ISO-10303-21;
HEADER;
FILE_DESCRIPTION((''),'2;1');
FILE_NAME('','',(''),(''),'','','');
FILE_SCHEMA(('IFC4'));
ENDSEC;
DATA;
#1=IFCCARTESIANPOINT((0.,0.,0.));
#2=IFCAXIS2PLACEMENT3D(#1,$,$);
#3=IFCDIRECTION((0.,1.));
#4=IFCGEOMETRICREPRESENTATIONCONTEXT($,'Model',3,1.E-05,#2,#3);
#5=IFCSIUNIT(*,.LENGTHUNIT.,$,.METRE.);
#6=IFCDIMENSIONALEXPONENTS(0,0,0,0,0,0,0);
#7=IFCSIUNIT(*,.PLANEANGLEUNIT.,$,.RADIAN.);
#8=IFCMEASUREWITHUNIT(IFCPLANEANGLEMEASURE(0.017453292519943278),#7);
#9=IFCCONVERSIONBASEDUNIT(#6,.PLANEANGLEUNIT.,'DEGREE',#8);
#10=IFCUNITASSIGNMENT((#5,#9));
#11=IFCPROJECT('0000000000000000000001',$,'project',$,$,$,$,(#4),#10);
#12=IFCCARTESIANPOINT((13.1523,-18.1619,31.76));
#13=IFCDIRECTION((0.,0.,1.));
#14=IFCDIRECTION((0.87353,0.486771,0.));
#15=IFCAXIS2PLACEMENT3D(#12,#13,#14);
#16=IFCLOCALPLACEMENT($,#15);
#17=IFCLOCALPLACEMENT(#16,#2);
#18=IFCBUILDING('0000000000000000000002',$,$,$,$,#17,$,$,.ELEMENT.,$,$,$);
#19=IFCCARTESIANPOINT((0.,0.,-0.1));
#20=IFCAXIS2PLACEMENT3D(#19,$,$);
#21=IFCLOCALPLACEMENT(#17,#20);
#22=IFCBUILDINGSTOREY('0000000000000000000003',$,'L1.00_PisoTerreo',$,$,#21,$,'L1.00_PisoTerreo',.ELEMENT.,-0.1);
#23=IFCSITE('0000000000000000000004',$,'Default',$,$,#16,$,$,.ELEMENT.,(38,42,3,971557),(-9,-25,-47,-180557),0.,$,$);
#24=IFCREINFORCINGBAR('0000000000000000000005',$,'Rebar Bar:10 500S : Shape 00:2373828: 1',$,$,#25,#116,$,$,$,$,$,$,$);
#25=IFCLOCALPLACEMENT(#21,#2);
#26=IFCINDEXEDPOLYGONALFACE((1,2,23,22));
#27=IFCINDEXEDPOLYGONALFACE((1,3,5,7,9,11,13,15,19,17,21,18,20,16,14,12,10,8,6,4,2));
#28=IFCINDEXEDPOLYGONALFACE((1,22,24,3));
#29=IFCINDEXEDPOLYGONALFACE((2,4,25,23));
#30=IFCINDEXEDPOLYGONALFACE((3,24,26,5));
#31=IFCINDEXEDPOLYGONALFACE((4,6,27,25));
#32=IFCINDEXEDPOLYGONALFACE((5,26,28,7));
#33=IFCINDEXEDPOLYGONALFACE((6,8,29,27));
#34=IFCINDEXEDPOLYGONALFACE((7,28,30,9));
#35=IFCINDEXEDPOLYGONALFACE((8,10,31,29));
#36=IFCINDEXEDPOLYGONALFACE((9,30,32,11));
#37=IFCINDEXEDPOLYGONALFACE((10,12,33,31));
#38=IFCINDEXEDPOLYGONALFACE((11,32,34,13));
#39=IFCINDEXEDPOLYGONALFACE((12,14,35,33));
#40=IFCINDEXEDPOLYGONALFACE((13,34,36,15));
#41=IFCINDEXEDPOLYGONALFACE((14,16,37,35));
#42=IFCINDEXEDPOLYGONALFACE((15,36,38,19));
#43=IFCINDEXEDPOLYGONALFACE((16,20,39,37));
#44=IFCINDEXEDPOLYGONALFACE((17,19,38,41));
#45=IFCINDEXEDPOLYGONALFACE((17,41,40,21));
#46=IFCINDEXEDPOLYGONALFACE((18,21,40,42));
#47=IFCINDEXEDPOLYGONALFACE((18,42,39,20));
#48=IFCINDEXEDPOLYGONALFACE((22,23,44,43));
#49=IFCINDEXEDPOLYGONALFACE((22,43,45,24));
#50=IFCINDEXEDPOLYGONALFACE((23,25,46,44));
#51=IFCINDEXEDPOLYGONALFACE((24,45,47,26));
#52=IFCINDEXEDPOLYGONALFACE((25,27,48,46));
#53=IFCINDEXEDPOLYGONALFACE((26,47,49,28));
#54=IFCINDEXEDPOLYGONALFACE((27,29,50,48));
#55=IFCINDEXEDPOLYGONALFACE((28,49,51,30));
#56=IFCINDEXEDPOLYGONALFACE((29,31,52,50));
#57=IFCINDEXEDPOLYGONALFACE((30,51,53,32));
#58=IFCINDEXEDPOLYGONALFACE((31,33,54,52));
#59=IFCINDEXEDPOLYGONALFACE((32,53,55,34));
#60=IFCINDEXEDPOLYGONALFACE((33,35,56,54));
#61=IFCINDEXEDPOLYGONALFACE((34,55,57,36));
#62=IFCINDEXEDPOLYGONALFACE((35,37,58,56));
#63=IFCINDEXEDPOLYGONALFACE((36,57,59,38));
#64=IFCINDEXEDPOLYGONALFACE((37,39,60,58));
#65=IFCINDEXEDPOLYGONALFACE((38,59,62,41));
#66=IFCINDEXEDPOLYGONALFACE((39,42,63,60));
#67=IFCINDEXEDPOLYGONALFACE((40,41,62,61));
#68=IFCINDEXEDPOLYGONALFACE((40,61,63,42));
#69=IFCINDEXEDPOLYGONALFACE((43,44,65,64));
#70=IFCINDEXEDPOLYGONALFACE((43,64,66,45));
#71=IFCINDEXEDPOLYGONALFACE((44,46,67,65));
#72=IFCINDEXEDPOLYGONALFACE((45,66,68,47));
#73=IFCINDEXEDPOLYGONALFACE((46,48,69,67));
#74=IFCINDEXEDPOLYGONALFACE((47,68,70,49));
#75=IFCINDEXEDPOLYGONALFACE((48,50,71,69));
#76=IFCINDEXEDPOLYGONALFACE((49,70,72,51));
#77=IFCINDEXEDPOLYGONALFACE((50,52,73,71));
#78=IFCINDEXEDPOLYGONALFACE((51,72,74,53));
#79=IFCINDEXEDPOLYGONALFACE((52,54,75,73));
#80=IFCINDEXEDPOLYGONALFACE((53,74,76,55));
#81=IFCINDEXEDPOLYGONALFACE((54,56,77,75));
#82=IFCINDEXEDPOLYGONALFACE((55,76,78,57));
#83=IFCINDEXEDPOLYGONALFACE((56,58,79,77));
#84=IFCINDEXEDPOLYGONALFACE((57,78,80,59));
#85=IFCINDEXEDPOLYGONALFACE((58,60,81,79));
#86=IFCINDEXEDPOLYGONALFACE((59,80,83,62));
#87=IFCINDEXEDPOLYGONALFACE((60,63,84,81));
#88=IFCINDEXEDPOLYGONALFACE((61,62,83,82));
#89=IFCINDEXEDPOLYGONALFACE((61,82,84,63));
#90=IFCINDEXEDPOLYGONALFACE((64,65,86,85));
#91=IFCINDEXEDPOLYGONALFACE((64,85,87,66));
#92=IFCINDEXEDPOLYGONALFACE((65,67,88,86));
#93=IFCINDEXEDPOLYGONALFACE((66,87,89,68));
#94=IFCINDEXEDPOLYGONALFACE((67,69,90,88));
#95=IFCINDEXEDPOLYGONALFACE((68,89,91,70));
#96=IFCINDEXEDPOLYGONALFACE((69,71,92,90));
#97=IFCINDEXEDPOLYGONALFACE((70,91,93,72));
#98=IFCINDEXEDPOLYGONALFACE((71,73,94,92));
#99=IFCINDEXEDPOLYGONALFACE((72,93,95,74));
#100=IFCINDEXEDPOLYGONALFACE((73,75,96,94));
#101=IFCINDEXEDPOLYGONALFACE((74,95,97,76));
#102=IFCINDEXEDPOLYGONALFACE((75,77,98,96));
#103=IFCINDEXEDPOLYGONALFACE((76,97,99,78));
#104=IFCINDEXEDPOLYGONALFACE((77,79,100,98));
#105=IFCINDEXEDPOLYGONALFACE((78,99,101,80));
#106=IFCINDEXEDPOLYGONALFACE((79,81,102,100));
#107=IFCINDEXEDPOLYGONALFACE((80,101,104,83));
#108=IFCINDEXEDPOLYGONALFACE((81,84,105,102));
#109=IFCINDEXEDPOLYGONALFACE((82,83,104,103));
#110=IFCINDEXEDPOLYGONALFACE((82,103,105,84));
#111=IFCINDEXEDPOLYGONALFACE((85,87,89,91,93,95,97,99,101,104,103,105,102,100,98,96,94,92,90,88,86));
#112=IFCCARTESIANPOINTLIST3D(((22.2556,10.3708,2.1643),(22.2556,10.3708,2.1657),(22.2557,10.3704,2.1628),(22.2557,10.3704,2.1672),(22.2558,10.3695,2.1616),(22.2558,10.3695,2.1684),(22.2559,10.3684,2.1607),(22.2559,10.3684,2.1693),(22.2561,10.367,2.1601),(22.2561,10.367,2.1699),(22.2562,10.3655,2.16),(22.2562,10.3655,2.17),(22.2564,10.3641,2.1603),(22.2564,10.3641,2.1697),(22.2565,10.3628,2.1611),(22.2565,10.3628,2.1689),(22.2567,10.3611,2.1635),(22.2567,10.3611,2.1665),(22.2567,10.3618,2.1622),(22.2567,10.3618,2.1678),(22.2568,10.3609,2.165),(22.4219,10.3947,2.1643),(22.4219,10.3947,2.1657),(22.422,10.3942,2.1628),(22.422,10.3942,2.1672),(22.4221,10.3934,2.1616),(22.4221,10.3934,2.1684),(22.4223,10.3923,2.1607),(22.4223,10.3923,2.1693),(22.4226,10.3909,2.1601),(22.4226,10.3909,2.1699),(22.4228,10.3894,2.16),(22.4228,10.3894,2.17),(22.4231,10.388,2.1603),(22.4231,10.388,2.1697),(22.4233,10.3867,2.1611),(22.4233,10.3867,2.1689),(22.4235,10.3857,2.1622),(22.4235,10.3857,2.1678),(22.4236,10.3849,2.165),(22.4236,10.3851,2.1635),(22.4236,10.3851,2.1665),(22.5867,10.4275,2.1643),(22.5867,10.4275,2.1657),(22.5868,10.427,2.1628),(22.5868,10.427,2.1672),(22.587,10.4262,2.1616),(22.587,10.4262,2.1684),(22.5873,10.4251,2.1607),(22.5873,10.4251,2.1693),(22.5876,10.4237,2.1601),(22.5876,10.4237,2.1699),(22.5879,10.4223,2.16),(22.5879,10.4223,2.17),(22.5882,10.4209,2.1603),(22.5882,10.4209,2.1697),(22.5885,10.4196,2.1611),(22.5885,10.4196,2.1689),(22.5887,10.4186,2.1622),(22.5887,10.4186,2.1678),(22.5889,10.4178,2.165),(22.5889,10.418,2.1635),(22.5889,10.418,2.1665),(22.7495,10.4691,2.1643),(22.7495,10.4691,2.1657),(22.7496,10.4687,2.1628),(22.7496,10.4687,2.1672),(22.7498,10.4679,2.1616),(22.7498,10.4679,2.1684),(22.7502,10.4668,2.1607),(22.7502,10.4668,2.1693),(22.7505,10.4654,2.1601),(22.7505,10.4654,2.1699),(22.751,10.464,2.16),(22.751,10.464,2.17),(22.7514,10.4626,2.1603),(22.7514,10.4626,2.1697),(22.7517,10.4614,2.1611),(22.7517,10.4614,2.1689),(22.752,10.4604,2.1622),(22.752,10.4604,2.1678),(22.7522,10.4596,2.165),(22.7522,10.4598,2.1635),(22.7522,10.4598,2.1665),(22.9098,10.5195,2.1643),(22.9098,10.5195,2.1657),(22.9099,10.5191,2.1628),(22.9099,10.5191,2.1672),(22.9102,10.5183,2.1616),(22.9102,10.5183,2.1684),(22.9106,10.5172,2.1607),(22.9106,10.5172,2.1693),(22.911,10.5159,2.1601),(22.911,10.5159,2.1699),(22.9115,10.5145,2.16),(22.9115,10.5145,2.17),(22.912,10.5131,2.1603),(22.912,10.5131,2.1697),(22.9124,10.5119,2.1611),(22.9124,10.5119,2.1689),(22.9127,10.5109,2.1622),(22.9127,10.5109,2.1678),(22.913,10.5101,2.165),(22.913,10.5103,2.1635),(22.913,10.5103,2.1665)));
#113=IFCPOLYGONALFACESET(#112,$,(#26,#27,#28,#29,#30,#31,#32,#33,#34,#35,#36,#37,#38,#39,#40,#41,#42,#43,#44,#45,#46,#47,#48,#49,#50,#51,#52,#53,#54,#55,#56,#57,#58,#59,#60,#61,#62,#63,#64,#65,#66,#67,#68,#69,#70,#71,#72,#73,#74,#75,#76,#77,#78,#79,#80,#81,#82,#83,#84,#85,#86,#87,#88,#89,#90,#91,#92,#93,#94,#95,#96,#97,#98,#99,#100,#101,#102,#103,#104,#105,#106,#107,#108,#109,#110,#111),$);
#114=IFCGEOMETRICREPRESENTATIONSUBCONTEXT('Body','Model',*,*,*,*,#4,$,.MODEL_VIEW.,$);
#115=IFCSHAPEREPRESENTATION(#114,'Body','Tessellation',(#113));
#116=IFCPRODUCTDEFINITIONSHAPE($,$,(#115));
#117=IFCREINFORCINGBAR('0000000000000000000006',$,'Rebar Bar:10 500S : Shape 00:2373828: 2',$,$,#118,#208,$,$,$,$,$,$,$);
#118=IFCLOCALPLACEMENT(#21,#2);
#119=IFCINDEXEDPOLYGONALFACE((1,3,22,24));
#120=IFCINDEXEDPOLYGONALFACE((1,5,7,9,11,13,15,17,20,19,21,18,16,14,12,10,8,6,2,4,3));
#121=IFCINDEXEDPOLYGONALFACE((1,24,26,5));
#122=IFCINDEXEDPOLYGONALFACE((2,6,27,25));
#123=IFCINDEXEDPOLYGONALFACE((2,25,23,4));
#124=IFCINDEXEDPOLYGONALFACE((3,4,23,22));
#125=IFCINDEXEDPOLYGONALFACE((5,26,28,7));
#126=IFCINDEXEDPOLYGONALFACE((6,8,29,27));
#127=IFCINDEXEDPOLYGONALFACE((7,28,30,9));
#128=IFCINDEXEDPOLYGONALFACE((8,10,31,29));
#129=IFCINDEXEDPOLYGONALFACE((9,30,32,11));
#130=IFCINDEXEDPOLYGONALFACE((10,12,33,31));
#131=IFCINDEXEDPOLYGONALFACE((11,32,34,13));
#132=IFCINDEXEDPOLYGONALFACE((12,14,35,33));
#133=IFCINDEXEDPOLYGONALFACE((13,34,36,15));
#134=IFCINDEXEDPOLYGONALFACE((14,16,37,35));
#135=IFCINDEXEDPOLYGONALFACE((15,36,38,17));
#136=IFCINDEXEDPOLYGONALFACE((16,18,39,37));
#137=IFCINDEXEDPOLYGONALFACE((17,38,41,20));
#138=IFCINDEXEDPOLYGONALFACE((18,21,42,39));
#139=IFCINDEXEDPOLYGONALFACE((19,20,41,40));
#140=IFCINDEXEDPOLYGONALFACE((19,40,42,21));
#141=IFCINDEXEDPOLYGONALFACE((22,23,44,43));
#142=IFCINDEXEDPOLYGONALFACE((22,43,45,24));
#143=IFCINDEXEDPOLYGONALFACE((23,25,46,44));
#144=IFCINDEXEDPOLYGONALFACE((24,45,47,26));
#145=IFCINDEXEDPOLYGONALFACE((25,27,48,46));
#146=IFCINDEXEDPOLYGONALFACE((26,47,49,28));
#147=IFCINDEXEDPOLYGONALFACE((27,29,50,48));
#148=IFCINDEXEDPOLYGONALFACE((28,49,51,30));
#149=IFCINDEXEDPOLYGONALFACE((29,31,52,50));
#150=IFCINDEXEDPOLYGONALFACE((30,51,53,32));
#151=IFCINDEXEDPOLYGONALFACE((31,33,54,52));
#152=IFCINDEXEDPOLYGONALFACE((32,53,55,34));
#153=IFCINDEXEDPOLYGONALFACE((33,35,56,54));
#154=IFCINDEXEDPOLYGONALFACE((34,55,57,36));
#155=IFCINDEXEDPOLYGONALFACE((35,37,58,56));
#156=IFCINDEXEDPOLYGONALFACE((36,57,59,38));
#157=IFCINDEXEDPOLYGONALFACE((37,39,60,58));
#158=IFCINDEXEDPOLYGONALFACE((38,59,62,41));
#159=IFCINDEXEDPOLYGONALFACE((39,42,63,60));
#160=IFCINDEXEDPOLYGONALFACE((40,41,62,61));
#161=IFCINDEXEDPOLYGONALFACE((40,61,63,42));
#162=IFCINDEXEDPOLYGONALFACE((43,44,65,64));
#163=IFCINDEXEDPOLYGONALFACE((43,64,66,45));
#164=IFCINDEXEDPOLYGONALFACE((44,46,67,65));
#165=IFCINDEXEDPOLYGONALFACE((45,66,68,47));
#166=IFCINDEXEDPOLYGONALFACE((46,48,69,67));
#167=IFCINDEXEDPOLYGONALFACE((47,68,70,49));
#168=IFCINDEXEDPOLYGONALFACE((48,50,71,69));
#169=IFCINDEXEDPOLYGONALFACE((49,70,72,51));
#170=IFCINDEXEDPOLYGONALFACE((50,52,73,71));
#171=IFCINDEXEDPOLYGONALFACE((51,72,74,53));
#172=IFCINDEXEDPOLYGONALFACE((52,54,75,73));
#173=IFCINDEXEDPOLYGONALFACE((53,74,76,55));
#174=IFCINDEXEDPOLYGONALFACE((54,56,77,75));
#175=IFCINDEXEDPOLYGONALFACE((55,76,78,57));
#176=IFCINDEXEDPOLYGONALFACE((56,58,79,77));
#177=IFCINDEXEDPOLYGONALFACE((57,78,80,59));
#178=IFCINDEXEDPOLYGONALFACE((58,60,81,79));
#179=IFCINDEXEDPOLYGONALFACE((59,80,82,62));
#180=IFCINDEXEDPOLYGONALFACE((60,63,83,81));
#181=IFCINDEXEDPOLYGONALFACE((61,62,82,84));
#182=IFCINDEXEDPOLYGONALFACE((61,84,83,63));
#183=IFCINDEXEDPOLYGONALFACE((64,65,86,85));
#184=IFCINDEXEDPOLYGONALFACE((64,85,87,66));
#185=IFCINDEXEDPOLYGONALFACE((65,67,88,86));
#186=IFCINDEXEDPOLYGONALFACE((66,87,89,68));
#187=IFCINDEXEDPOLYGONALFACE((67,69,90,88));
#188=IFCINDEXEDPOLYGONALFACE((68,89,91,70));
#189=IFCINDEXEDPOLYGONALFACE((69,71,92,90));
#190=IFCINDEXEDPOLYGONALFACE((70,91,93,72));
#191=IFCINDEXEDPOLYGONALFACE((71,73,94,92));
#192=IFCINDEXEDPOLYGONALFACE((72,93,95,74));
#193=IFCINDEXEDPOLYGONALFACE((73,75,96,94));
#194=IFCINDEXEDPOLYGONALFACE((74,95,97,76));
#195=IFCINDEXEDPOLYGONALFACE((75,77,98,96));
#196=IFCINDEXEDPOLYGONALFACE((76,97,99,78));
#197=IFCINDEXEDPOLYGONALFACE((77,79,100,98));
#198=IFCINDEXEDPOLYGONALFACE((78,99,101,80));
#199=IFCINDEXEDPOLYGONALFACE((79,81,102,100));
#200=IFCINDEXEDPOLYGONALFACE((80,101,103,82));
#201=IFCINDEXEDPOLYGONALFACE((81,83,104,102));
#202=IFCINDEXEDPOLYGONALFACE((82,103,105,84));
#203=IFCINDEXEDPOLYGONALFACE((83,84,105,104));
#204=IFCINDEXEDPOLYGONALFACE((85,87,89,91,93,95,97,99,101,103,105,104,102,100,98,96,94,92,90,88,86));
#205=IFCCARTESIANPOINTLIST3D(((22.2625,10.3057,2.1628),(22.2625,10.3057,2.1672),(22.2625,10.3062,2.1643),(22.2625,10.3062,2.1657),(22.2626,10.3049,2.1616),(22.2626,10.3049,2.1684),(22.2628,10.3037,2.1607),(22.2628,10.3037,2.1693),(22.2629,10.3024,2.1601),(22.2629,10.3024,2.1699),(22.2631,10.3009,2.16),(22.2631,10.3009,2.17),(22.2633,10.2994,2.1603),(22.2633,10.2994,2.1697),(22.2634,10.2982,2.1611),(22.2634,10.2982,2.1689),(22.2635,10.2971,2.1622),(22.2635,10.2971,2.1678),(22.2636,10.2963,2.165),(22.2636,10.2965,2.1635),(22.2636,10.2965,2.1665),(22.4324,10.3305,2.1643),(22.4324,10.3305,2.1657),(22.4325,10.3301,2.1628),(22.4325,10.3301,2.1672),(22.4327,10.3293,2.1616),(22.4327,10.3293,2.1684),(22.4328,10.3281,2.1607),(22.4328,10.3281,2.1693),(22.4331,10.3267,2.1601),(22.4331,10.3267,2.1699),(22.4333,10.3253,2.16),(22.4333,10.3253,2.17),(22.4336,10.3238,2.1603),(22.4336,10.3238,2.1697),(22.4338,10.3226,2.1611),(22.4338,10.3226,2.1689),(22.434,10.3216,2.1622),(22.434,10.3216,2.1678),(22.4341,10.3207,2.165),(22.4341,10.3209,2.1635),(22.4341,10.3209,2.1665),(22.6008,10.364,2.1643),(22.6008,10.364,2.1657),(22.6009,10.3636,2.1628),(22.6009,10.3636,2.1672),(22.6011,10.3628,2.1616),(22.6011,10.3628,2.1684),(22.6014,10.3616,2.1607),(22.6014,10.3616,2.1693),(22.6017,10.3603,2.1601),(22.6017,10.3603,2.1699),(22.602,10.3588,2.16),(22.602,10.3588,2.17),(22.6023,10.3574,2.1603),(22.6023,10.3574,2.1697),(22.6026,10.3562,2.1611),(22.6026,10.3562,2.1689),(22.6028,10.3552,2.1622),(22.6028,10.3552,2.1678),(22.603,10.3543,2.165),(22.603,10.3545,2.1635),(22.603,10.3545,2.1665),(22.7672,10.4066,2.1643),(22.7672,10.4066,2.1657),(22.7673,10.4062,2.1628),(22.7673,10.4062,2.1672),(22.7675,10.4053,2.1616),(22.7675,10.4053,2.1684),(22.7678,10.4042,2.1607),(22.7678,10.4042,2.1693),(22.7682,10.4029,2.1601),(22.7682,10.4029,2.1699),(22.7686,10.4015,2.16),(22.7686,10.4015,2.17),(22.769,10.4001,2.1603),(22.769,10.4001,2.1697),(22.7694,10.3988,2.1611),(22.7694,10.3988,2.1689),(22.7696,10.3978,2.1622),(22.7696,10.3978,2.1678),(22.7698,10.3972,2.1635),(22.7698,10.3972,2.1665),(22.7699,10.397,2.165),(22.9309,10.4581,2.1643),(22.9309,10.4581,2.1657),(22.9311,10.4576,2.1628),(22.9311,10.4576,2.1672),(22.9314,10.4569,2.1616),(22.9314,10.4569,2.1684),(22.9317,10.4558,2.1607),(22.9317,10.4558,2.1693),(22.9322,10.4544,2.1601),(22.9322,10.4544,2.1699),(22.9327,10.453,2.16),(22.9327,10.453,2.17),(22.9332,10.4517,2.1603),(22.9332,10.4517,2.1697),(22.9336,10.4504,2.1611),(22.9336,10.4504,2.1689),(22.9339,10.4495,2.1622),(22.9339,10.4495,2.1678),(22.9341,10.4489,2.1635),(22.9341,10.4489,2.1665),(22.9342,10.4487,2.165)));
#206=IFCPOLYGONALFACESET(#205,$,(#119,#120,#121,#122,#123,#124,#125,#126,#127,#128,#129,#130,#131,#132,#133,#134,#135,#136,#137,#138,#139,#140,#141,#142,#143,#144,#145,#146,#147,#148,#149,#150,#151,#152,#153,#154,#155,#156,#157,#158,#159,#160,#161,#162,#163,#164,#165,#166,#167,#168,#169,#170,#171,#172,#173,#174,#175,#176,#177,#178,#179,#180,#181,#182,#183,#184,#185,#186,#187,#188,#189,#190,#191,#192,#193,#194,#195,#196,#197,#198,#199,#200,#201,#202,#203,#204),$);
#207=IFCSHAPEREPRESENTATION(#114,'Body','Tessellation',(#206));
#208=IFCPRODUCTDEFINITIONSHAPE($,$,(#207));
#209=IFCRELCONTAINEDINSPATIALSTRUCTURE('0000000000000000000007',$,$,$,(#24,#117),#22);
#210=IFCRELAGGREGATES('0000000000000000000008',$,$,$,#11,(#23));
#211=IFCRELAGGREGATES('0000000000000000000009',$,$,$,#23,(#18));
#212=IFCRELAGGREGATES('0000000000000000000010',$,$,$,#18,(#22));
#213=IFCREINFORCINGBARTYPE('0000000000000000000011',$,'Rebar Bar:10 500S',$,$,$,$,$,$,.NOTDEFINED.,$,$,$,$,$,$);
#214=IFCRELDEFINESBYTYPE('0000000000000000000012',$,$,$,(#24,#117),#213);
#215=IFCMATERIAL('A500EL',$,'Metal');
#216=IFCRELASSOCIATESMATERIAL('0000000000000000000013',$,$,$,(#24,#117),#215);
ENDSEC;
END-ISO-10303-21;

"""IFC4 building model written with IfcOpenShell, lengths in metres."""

from ifc_helpers import new_model, entity, si_unit, converted_unit, direction, frame, origin, place, context, subcontext, project, spatial, material, type_object, element, save


model = new_model("IFC4")

# Units and contexts
model_context = context("Model", 3, precision=1e-05, world=origin(), true_north=direction((0.0, 1.0)))
body_context = subcontext(model_context, "Body", "Model", "MODEL_VIEW")
ifc_project = project(units=[si_unit("LENGTHUNIT", "METRE"), converted_unit("PLANEANGLEUNIT", "DEGREE", entity("IfcPlaneAngleMeasure", 0.017453292519943278), si_unit("PLANEANGLEUNIT", "RADIAN"), dimensions=[0, 0, 0, 0, 0, 0, 0])], contexts=[model_context])

# Site, building, storey
site_placement = place(None, frame((13.1523, -18.1619, 31.76), z_axis=(0.0, 0.0, 1.0), x_axis=(0.87353, 0.486771, 0.0)))
site = spatial("IfcSite", under=ifc_project, at=site_placement, Name="Default", CompositionType="ELEMENT", RefLatitude=(38, 42, 3, 971557), RefLongitude=(-9, -25, -47, -180557), RefElevation=0.0)
building_placement = place(site_placement, origin())
building = spatial("IfcBuilding", under=site, at=building_placement, CompositionType="ELEMENT")
storey_placement = place(building_placement, frame((0.0, 0.0, -0.1)))
storey = spatial("IfcBuildingStorey", under=building, at=storey_placement, Name="L1.00_PisoTerreo", LongName="L1.00_PisoTerreo", CompositionType="ELEMENT", Elevation=-0.1)

# Reinforcing bars
ifc_material = material(Name="A500EL", Category="Metal")
reinforcing_bar_type_1 = type_object("IfcReinforcingBarType", Name="Rebar Bar:10 500S", PredefinedType="NOTDEFINED")
reinforcing_bar_1_placement = place(storey_placement, origin())
element("IfcReinforcingBar", 1, at=reinforcing_bar_1_placement, inside=storey, type_object=reinforcing_bar_type_1, material=ifc_material, Name="Rebar Bar:10 500S : Shape 00:2373828: 1", context=body_context, shape_type="AdvancedSweptSolid", body=[
    entity("IfcSweptDiskSolid", entity("IfcIndexedPolyCurve", entity("IfcCartesianPointList3D", [[22.9114, 10.5148, 2.165], [22.5878, 10.4226, 2.165], [22.2562, 10.3659, 2.165]]), [entity("IfcArcIndex", [1, 2, 3])], False), 0.005, None, 0.0, 12.3834),
])
reinforcing_bar_2_placement = place(storey_placement, origin())
element("IfcReinforcingBar", 2, at=reinforcing_bar_2_placement, inside=storey, type_object=reinforcing_bar_type_1, material=ifc_material, Name="Rebar Bar:10 500S : Shape 00:2373828: 2", context=body_context, shape_type="AdvancedSweptSolid", body=[
    entity("IfcSweptDiskSolid", entity("IfcIndexedPolyCurve", entity("IfcCartesianPointList3D", [[22.9326, 10.4534, 2.165], [22.6019, 10.3592, 2.165], [22.263, 10.3012, 2.165]]), [entity("IfcArcIndex", [1, 2, 3])], False), 0.005, None, 0.0, 12.3946),
])

save(model, "model.ifc")
